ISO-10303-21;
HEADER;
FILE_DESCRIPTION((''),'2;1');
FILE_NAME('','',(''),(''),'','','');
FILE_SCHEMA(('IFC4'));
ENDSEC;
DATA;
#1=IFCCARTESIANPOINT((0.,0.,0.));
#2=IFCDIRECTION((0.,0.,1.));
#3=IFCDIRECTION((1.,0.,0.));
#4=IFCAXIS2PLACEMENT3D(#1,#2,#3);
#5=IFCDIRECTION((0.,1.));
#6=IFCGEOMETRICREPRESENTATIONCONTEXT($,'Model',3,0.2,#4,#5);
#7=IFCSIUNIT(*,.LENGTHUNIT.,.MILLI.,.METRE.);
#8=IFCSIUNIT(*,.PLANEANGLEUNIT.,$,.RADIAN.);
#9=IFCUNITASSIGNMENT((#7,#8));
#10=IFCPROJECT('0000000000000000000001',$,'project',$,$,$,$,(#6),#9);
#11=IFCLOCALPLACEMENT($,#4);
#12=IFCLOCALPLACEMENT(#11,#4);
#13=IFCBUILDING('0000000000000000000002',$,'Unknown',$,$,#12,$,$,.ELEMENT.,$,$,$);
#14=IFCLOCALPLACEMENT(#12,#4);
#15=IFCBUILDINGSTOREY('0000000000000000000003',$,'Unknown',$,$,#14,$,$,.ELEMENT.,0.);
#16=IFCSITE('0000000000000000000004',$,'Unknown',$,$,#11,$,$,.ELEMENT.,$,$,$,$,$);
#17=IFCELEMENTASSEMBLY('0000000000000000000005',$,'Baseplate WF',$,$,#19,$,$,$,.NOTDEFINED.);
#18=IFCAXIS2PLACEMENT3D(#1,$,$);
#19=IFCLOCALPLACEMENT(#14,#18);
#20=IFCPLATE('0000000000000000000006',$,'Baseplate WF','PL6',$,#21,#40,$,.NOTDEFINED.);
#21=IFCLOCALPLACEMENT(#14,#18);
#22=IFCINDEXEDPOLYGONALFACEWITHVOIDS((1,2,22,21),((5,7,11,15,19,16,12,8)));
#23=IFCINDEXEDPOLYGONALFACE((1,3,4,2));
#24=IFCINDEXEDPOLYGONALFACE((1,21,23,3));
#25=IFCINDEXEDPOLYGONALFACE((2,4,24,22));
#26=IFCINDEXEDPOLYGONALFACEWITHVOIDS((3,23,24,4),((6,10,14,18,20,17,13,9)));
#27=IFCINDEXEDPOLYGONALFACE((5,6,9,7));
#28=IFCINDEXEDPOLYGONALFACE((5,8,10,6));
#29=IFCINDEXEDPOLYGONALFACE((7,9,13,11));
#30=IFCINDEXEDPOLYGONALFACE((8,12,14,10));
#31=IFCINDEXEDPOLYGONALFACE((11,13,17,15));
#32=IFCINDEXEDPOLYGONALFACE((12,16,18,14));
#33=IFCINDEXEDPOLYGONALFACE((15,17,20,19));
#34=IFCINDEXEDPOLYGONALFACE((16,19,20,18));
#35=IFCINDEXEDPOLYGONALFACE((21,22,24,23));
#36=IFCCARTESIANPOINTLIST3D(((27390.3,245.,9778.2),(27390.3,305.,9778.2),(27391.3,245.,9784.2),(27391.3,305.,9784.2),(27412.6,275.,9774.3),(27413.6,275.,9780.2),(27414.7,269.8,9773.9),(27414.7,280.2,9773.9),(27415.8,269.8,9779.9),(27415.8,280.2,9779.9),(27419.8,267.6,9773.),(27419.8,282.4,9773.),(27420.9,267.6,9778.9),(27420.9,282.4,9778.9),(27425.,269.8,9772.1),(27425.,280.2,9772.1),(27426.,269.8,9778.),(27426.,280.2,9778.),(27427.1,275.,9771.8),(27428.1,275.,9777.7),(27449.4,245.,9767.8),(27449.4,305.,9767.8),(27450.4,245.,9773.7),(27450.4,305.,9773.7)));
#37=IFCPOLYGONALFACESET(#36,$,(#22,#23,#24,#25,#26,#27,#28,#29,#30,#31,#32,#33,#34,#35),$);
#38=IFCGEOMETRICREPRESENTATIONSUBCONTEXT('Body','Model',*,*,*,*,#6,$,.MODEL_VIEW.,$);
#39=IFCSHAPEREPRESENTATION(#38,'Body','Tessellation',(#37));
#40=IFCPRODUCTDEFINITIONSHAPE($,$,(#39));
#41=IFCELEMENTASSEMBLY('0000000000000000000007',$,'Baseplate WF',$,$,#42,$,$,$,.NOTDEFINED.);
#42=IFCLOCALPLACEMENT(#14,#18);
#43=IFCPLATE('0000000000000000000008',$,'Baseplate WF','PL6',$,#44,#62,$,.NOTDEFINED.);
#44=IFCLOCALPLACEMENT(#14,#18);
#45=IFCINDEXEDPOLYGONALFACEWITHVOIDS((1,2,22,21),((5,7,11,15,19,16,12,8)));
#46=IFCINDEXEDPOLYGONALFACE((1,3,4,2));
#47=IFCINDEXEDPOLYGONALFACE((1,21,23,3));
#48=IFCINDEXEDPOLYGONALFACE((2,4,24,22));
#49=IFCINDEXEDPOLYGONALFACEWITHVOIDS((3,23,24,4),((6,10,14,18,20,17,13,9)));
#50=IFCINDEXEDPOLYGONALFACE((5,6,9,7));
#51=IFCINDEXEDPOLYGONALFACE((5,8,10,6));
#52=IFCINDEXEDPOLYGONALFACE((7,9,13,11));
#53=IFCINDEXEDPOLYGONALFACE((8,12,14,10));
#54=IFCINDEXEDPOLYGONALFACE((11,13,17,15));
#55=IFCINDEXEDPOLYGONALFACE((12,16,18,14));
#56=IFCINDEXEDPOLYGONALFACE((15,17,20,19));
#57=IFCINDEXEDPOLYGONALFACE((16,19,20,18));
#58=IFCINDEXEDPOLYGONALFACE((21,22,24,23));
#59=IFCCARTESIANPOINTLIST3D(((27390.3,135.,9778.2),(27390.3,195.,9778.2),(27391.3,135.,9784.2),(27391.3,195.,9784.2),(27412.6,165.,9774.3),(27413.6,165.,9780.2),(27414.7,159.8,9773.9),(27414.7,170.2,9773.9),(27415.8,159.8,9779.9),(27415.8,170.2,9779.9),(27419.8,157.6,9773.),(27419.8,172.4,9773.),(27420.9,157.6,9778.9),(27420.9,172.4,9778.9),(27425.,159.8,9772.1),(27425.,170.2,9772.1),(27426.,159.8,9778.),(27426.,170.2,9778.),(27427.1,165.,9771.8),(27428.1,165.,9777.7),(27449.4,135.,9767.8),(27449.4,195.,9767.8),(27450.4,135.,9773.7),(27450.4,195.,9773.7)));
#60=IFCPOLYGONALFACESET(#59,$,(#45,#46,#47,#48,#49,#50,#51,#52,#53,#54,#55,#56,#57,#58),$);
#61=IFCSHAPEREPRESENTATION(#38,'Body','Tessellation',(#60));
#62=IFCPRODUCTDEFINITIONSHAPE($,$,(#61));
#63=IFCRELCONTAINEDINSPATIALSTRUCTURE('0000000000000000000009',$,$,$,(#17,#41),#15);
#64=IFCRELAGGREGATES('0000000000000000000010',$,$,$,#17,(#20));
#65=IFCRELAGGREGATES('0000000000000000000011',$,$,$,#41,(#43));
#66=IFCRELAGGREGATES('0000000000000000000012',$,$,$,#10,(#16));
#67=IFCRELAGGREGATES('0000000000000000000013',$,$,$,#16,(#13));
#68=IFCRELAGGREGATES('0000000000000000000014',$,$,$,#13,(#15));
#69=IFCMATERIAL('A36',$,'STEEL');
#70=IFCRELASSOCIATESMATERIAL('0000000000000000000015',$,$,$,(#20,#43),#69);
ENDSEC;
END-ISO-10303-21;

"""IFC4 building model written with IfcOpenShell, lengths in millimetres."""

from ifc_helpers import new_model, si_unit, direction, frame, origin_with_axes, place, context, subcontext, project, spatial, line, indexed_curve, outline, extrude, material, element, aggregate, save


model = new_model("IFC4")

# Units and contexts
model_context = context("Model", 3, precision=0.2, world=origin_with_axes(), true_north=direction((0.0, 1.0)))
body_context = subcontext(model_context, "Body", "Model", "MODEL_VIEW")
ifc_project = project(units=[si_unit("LENGTHUNIT", "METRE", prefix="MILLI"), si_unit("PLANEANGLEUNIT", "RADIAN")], contexts=[model_context])

# Site, building, storey
site_placement = place(None, origin_with_axes())
site = spatial("IfcSite", under=ifc_project, at=site_placement, Name="Unknown", CompositionType="ELEMENT")
building_placement = place(site_placement, origin_with_axes())
building = spatial("IfcBuilding", under=site, at=building_placement, Name="Unknown", CompositionType="ELEMENT")
storey_placement = place(building_placement, origin_with_axes())
storey = spatial("IfcBuildingStorey", under=building, at=storey_placement, Name="Unknown", CompositionType="ELEMENT", Elevation=0.0)

# Element assemblies, plates, voiding features
ifc_material_1 = material(Name="A36", Category="STEEL")
assembly_1_placement = place(storey_placement, frame((27449.9, 305.0, 9770.8), z_axis=(-0.173648, 0.0, -0.984808), x_axis=(0.0, -1.0, 0.0)))
assembly_1 = element("IfcElementAssembly", 1, at=assembly_1_placement, inside=storey, Name="Baseplate WF", PredefinedType="NOTDEFINED")
plate_1_placement = place(assembly_1_placement, origin_with_axes())
plate_1 = element("IfcPlate", 2, at=plate_1_placement, material=ifc_material_1, Name="Baseplate WF", Description="PL6", PredefinedType="NOTDEFINED", context=body_context, shape_type="SolidModel", body=[
    extrude(outline(indexed_curve([(0.0, 0.0), (60.0, 0.0), (60.0, 60.0), (0.0, 60.0)], segments=[line(1, 2, 3, 4, 1)])), frame((0.0, 0.0, 3.0), z_axis=(0.0, 0.0, 1.0), x_axis=(1.0, 0.0, 0.0)), (0.0, 0.0, -1.0), 6.0),
])
voiding_feature_1_placement = place(plate_1_placement, frame((140.0, 30.0, -3.5), z_axis=(-1.0, 0.0, 0.0), x_axis=(0.0, 0.0, 1.0)))
element("IfcVoidingFeature", 3, at=voiding_feature_1_placement, cuts=plate_1, Name="BEAM", PredefinedType="HOLE", context=body_context, shape_type="SolidModel", body=[
    extrude(outline(indexed_curve([(7.4, 0.0), (5.2, 5.2), (0.0, 7.4), (-5.2, 5.2), (-7.4, 0.0), (-5.2, -5.2), (0.0, -7.4), (5.2, -5.2)], segments=[line(1, 2, 3, 4, 5, 6, 7, 8, 1)])), frame((0.0, 0.0, 0.0), z_axis=(-1.0, 0.0, 0.0), x_axis=(0.0, 0.0, 1.0)), (0.0, 0.0, -1.0), 7.0),
])
voiding_feature_2_placement = place(plate_1_placement, frame((30.0, 30.0, -3.5), z_axis=(-1.0, 0.0, 0.0), x_axis=(0.0, 0.0, 1.0)))
element("IfcVoidingFeature", 4, at=voiding_feature_2_placement, cuts=plate_1, Name="BEAM", PredefinedType="HOLE", context=body_context, shape_type="SolidModel", body=[
    extrude(outline(indexed_curve([(7.4, 0.0), (5.2, 5.2), (0.0, 7.4), (-5.2, 5.2), (-7.4, 0.0), (-5.2, -5.2), (0.0, -7.4), (5.2, -5.2)], segments=[line(1, 2, 3, 4, 5, 6, 7, 8, 1)])), frame((0.0, 0.0, 0.0), z_axis=(-1.0, 0.0, 0.0), x_axis=(0.0, 0.0, 1.0)), (0.0, 0.0, -1.0), 7.0),
])
aggregate(assembly_1, [plate_1])
assembly_2_placement = place(storey_placement, frame((27449.9, 195.0, 9770.8), z_axis=(-0.173648, 0.0, -0.984808), x_axis=(0.0, -1.0, 0.0)))
assembly_2 = element("IfcElementAssembly", 5, at=assembly_2_placement, inside=storey, Name="Baseplate WF", PredefinedType="NOTDEFINED")
plate_2_placement = place(assembly_2_placement, origin_with_axes())
plate_2 = element("IfcPlate", 6, at=plate_2_placement, material=ifc_material_1, Name="Baseplate WF", Description="PL6", PredefinedType="NOTDEFINED", context=body_context, shape_type="SolidModel", body=[
    extrude(outline(indexed_curve([(0.0, 0.0), (60.0, 0.0), (60.0, 60.0), (0.0, 60.0)], segments=[line(1, 2, 3, 4, 1)])), frame((0.0, 0.0, 3.0), z_axis=(0.0, 0.0, 1.0), x_axis=(1.0, 0.0, 0.0)), (0.0, 0.0, -1.0), 6.0),
])
voiding_feature_3_placement = place(plate_2_placement, frame((30.0, 30.0, -3.5), z_axis=(-1.0, 0.0, 0.0), x_axis=(0.0, 0.0, 1.0)))
element("IfcVoidingFeature", 7, at=voiding_feature_3_placement, cuts=plate_2, Name="BEAM", PredefinedType="HOLE", context=body_context, shape_type="SolidModel", body=[
    extrude(outline(indexed_curve([(7.4, 0.0), (5.2, 5.2), (0.0, 7.4), (-5.2, 5.2), (-7.4, 0.0), (-5.2, -5.2), (0.0, -7.4), (5.2, -5.2)], segments=[line(1, 2, 3, 4, 5, 6, 7, 8, 1)])), frame((0.0, 0.0, 0.0), z_axis=(-1.0, 0.0, 0.0), x_axis=(0.0, 0.0, 1.0)), (0.0, 0.0, -1.0), 7.0),
])
voiding_feature_4_placement = place(plate_2_placement, frame((-80.0, 30.0, -3.5), z_axis=(-1.0, 0.0, 0.0), x_axis=(0.0, 0.0, 1.0)))
element("IfcVoidingFeature", 8, at=voiding_feature_4_placement, cuts=plate_2, Name="BEAM", PredefinedType="HOLE", context=body_context, shape_type="SolidModel", body=[
    extrude(outline(indexed_curve([(7.4, 0.0), (5.2, 5.2), (0.0, 7.4), (-5.2, 5.2), (-7.4, 0.0), (-5.2, -5.2), (0.0, -7.4), (5.2, -5.2)], segments=[line(1, 2, 3, 4, 5, 6, 7, 8, 1)])), frame((0.0, 0.0, 0.0), z_axis=(-1.0, 0.0, 0.0), x_axis=(0.0, 0.0, 1.0)), (0.0, 0.0, -1.0), 7.0),
])
aggregate(assembly_2, [plate_2])

save(model, "model.ifc")
